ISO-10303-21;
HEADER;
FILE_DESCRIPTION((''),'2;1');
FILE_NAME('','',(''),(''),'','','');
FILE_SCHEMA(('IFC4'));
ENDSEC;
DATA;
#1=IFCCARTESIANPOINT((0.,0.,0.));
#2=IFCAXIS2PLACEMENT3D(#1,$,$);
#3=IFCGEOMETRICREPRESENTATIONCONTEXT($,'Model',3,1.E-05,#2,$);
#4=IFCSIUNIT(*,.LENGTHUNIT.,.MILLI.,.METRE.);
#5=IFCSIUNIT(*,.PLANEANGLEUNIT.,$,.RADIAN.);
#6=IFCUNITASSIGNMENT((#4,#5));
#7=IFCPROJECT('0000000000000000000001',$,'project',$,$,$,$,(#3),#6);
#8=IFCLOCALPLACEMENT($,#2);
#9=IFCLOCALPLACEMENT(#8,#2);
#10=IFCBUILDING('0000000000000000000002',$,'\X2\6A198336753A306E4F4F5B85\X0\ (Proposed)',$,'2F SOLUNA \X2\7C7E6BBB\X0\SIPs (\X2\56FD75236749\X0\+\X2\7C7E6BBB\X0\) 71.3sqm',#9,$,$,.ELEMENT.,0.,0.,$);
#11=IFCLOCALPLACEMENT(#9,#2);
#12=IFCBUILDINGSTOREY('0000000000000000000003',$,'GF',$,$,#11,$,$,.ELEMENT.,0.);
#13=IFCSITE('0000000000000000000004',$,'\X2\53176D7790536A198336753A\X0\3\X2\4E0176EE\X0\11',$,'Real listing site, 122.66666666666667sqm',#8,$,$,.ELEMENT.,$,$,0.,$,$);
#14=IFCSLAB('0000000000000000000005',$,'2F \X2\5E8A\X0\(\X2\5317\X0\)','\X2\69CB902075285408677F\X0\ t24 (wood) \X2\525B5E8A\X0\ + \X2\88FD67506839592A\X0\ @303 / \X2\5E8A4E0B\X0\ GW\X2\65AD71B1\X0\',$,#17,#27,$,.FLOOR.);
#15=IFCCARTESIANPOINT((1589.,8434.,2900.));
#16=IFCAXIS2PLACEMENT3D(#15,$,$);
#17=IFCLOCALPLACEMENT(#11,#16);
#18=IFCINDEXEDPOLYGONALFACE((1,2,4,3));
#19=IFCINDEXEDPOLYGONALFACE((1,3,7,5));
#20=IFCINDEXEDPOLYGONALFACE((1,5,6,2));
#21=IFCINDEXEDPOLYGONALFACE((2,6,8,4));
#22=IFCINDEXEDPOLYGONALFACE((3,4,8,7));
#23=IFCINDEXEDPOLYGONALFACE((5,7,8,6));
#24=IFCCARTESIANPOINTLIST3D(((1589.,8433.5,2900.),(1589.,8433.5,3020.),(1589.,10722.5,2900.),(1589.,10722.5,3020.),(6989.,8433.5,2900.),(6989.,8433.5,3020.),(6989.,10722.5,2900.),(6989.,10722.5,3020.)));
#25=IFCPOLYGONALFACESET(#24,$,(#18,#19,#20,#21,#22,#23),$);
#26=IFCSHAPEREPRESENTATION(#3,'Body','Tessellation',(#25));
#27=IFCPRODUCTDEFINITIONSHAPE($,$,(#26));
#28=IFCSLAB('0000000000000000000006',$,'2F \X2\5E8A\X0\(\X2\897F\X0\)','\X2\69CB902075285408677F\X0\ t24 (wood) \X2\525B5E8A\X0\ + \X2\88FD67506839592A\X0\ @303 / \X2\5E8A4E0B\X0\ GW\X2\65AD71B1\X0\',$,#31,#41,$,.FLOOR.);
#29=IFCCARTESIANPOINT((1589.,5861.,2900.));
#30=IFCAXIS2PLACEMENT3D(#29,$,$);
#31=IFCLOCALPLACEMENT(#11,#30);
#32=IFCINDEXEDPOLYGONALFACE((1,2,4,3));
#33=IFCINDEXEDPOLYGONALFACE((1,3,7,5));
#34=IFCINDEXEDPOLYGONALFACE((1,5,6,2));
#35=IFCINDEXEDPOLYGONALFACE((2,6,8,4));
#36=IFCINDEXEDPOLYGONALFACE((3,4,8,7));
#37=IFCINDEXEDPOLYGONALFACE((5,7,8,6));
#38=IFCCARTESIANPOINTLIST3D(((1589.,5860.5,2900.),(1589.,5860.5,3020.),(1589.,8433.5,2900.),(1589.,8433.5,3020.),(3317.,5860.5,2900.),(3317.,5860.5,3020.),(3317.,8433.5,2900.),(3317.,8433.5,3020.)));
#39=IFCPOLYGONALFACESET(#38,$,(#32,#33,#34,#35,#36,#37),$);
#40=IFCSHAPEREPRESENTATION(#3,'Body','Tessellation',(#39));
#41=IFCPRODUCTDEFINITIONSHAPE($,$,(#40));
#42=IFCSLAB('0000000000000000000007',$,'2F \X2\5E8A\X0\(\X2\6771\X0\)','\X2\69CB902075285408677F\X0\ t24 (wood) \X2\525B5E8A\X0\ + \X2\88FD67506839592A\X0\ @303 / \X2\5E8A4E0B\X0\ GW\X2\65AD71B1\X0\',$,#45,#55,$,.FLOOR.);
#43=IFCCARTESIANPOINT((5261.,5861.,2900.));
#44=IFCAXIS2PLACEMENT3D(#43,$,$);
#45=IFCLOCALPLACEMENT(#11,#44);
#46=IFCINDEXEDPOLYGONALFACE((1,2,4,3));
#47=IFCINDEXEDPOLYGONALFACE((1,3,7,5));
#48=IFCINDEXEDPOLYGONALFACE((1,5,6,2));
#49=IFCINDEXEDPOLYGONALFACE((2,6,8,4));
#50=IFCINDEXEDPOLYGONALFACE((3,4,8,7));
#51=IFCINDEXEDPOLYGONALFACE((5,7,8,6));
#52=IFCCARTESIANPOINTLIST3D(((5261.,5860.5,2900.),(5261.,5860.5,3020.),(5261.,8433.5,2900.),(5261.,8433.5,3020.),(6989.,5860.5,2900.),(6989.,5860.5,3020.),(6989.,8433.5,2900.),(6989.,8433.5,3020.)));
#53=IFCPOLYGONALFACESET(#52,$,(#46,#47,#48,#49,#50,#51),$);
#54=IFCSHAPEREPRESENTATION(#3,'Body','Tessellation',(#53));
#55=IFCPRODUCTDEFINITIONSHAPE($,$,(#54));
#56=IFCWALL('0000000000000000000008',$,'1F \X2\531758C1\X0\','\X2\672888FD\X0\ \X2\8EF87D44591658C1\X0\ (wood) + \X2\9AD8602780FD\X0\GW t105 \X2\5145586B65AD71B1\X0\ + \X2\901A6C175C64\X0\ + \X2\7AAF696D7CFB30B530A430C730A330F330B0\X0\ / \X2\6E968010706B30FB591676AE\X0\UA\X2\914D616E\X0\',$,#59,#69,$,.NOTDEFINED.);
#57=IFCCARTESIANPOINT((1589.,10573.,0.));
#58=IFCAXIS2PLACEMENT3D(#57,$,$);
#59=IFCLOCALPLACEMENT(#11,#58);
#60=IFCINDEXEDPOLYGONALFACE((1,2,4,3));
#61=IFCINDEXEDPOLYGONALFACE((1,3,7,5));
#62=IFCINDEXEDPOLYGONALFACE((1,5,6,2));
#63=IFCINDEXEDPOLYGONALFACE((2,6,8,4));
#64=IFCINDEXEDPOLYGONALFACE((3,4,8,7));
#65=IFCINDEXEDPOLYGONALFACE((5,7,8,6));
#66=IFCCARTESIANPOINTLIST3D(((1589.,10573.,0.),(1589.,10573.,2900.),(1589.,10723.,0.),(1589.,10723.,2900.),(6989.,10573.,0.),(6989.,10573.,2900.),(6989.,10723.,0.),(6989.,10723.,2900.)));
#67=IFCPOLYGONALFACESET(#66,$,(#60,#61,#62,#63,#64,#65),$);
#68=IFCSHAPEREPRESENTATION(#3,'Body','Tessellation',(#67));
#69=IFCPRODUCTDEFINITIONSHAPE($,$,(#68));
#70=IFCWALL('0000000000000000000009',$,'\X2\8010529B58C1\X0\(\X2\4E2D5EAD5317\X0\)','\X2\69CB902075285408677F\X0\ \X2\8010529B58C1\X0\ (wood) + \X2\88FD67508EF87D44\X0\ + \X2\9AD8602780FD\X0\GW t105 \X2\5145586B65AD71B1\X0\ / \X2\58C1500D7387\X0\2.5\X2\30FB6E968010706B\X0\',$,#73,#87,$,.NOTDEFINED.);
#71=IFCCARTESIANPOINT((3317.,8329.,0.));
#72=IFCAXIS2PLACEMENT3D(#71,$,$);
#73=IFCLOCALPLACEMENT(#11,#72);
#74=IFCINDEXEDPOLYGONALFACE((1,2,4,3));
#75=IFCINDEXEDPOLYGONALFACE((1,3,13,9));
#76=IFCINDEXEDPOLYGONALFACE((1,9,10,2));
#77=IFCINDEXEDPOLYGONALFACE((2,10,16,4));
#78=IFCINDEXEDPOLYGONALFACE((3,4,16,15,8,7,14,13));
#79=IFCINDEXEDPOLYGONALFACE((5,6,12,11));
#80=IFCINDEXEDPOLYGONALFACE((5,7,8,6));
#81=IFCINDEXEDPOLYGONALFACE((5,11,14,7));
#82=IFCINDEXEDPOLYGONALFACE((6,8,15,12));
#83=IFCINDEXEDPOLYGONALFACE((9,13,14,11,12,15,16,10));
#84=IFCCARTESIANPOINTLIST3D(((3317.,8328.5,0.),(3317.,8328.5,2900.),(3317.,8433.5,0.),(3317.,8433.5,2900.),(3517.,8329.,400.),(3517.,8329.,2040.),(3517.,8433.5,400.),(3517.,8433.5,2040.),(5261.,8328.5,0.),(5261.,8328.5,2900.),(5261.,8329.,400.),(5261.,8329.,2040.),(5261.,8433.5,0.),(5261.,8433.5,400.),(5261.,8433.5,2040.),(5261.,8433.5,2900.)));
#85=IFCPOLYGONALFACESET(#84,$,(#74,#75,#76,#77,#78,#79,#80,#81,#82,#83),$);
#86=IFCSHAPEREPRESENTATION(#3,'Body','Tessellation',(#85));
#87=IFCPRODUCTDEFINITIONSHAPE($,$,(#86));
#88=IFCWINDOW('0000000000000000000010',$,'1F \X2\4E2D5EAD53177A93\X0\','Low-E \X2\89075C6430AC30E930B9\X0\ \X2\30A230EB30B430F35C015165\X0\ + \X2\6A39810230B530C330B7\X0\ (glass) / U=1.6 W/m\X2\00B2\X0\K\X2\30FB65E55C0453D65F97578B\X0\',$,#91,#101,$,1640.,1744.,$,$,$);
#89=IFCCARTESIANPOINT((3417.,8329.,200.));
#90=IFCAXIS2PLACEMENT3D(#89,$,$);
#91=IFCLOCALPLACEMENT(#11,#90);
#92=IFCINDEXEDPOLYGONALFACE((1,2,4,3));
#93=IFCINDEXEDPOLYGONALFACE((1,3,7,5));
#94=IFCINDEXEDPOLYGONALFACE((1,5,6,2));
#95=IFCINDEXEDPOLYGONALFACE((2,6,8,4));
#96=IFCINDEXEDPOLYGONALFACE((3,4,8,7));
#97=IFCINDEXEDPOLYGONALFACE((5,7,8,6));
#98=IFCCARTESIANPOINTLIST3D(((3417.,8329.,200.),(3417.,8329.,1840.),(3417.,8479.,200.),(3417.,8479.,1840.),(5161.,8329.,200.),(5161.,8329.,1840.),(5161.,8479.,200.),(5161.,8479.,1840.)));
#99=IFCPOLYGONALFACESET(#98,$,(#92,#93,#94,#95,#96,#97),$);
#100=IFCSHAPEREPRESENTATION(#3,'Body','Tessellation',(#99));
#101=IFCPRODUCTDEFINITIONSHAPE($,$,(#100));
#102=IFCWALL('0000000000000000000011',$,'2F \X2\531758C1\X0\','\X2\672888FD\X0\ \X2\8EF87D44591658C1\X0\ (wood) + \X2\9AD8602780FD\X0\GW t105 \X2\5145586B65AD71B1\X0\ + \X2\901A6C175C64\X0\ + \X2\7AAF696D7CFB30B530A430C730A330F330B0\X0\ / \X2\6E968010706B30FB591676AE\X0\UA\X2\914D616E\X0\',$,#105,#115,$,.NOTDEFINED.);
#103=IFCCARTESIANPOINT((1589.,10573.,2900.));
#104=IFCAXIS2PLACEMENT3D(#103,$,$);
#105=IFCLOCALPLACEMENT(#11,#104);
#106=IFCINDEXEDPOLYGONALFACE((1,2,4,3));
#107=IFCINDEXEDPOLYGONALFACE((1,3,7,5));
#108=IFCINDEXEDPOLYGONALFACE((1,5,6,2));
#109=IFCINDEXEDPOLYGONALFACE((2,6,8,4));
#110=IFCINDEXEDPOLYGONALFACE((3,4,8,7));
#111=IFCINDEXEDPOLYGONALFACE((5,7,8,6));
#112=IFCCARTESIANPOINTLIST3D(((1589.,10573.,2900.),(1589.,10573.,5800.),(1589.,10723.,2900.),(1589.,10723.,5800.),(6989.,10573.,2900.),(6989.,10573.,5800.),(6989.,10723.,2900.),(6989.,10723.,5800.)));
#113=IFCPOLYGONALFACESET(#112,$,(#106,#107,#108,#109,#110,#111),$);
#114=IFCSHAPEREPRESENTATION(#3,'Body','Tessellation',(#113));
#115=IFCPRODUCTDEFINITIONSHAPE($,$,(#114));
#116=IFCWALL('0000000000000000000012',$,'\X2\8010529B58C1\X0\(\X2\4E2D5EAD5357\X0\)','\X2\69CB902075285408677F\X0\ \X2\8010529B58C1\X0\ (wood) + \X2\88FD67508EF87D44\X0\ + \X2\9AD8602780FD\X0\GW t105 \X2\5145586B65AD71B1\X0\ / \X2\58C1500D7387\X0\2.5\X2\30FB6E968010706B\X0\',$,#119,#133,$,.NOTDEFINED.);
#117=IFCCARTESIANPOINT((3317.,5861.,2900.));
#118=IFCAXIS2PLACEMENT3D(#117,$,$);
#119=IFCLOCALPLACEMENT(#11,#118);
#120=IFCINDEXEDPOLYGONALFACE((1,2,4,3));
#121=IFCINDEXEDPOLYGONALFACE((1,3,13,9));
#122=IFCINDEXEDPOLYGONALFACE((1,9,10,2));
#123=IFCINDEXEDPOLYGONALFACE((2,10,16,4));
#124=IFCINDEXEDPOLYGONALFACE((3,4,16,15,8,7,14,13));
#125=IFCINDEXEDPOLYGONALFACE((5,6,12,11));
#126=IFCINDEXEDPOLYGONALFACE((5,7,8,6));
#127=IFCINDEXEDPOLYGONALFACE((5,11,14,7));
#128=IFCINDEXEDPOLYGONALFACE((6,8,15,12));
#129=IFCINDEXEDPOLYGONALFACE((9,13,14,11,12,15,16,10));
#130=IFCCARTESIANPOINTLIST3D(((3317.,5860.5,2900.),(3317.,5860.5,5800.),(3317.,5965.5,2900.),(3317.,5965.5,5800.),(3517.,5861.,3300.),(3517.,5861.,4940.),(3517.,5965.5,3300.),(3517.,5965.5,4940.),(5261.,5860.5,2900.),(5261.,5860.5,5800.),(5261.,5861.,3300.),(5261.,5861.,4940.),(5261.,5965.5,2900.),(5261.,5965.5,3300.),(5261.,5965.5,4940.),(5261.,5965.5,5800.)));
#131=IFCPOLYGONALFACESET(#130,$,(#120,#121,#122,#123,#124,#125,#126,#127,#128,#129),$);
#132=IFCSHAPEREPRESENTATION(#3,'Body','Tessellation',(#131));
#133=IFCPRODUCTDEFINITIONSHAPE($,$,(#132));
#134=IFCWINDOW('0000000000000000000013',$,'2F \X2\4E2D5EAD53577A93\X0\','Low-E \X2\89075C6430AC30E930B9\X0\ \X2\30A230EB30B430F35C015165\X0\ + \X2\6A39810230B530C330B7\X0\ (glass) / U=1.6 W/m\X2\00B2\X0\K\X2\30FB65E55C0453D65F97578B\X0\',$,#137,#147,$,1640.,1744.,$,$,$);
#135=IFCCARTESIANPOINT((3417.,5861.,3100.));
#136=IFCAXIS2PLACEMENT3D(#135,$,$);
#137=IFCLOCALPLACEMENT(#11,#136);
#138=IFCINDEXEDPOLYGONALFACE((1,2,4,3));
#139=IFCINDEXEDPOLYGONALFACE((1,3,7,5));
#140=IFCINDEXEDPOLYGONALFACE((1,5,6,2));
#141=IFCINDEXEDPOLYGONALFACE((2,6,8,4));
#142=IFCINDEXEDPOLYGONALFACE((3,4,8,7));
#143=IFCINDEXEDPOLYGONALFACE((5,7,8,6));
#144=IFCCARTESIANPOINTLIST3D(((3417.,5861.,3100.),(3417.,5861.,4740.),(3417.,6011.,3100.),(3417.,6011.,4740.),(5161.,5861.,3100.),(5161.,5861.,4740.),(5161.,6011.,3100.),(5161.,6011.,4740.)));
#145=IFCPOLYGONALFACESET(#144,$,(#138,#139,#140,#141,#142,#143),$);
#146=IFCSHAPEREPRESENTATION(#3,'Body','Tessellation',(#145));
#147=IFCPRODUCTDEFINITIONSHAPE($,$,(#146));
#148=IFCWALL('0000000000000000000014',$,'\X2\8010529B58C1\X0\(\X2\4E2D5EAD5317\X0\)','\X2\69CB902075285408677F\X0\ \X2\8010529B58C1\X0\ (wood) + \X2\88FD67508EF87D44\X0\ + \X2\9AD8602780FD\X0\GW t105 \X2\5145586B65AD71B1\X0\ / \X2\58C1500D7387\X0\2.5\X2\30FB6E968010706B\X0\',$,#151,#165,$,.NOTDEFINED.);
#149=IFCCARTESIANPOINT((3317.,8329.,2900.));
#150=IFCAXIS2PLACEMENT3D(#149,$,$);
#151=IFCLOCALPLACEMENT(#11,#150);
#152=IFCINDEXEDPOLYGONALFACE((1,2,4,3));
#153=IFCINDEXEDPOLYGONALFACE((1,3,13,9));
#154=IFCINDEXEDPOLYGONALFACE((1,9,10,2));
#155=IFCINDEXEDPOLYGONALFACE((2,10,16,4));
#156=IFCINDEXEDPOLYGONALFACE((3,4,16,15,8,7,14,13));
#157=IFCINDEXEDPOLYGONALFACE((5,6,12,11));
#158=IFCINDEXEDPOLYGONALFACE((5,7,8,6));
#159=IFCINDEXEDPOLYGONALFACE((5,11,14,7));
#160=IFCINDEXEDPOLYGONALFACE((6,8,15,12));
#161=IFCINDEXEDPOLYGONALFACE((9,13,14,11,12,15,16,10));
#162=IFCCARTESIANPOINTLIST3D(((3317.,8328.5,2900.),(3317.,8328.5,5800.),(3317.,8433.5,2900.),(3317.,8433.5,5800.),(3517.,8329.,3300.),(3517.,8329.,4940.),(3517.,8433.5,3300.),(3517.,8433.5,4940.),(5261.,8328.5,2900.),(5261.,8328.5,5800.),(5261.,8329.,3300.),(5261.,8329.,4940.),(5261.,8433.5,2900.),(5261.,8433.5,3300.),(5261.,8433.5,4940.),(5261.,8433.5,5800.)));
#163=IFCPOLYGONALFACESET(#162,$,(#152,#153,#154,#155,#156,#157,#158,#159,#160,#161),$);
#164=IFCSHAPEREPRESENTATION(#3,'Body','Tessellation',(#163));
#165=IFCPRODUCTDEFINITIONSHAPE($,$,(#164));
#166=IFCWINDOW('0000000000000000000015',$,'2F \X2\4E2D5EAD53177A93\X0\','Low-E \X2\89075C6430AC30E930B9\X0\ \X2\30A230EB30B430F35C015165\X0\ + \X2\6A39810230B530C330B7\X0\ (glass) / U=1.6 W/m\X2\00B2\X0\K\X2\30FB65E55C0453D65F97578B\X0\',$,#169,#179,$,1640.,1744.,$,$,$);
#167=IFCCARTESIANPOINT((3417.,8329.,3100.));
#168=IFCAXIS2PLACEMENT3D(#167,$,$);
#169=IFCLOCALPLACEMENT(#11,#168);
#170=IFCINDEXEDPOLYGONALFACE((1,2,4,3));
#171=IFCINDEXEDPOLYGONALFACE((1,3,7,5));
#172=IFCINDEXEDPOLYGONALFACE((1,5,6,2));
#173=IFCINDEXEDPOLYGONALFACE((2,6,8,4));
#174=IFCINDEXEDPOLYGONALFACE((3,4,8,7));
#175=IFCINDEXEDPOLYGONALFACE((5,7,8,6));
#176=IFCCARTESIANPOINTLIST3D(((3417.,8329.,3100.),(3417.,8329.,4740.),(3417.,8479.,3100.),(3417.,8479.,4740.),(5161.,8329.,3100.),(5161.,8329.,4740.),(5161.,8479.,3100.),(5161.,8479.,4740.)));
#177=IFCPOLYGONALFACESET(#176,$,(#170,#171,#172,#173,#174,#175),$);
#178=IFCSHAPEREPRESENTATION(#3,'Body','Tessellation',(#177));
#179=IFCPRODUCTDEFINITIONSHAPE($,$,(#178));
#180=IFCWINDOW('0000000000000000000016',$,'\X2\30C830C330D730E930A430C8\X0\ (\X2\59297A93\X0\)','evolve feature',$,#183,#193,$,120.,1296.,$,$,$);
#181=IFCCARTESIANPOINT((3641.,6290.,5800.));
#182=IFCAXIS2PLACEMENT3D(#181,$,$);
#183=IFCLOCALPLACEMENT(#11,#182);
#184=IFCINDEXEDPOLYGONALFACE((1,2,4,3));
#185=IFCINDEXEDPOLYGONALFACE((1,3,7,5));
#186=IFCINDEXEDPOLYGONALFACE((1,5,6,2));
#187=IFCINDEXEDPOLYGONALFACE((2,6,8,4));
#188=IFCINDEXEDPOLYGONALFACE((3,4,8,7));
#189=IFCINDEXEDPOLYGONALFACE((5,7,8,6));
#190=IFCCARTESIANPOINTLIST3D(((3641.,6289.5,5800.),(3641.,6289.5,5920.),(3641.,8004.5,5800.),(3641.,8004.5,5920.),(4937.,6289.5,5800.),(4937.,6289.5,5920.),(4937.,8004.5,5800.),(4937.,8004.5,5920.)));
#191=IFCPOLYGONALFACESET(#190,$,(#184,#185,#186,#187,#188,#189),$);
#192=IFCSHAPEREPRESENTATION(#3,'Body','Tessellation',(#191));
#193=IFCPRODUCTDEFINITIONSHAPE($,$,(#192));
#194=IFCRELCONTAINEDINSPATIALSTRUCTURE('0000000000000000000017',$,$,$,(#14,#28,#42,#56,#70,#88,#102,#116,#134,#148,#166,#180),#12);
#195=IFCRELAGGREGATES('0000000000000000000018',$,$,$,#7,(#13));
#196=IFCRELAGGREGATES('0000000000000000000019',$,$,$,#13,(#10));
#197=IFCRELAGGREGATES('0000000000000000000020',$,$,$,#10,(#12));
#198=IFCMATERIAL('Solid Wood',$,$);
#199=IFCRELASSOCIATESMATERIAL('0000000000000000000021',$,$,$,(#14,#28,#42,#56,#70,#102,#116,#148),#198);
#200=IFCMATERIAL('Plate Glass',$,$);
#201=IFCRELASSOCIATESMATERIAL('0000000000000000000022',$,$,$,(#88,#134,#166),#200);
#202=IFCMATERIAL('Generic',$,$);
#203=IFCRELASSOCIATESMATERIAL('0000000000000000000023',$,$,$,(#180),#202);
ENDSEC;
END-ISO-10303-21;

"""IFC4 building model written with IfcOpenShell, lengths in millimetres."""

from ifc_helpers import new_model, si_unit, frame, frame_2d, origin, place, context, project, spatial, rectangle, extrude, material, element, fill, save


model = new_model("IFC4")

# Units and contexts
model_context = context("Model", 3, precision=1e-05, world=origin())
ifc_project = project(units=[si_unit("LENGTHUNIT", "METRE", prefix="MILLI"), si_unit("PLANEANGLEUNIT", "RADIAN")], contexts=[model_context])

# Site, building, storey
site_placement = place(None, origin())
site = spatial("IfcSite", under=ifc_project, at=site_placement, Name="北海道標茶町3丁目11", ObjectType="Real listing site, 122.66666666666667sqm", CompositionType="ELEMENT", RefElevation=0.0)
building_placement = place(site_placement, origin())
building = spatial("IfcBuilding", under=site, at=building_placement, Name="標茶町の住宅 (Proposed)", ObjectType="2F SOLUNA 籾殻SIPs (国産杉+籾殻) 71.3sqm", CompositionType="ELEMENT", ElevationOfRefHeight=0.0, ElevationOfTerrain=0.0)
storey_placement = place(building_placement, origin())
storey = spatial("IfcBuildingStorey", under=building, at=storey_placement, Name="GF", CompositionType="ELEMENT", Elevation=0.0)

# Slabs
ifc_material_1 = material(Name="Solid Wood")
slab_1_placement = place(storey_placement, frame((1589.0, 8434.0, 2900.0)))
element("IfcSlab", 1, at=slab_1_placement, inside=storey, material=ifc_material_1, Name="2F 床(北)", Description="構造用合板 t24 (wood) 剛床 + 製材根太 @303 / 床下 GW断熱", PredefinedType="FLOOR", context=model_context, shape_type="SweptSolid", body=[
    extrude(rectangle(XDim=5400.0, YDim=2289.0, at=frame_2d((2700.0, 1144.0))), frame((1589.0, 8434.0, 2900.0)), (0.0, 0.0, 1.0), 120.0),
])
slab_2_placement = place(storey_placement, frame((1589.0, 5861.0, 2900.0)))
element("IfcSlab", 2, at=slab_2_placement, inside=storey, material=ifc_material_1, Name="2F 床(西)", Description="構造用合板 t24 (wood) 剛床 + 製材根太 @303 / 床下 GW断熱", PredefinedType="FLOOR", context=model_context, shape_type="SweptSolid", body=[
    extrude(rectangle(XDim=1728.0, YDim=2573.0, at=frame_2d((864.0, 1286.0))), frame((1589.0, 5861.0, 2900.0)), (0.0, 0.0, 1.0), 120.0),
])
slab_3_placement = place(storey_placement, frame((5261.0, 5861.0, 2900.0)))
element("IfcSlab", 3, at=slab_3_placement, inside=storey, material=ifc_material_1, Name="2F 床(東)", Description="構造用合板 t24 (wood) 剛床 + 製材根太 @303 / 床下 GW断熱", PredefinedType="FLOOR", context=model_context, shape_type="SweptSolid", body=[
    extrude(rectangle(XDim=1728.0, YDim=2573.0, at=frame_2d((864.0, 1286.0))), frame((5261.0, 5861.0, 2900.0)), (0.0, 0.0, 1.0), 120.0),
])

# Wall
wall_1_placement = place(storey_placement, frame((1589.0, 10573.0, 0.0)))
element("IfcWall", 4, at=wall_1_placement, inside=storey, material=ifc_material_1, Name="1F 北壁", Description="木製 軸組外壁 (wood) + 高性能GW t105 充填断熱 + 通気層 + 窯業系サイディング / 準耐火・外皮UA配慮", PredefinedType="NOTDEFINED", context=model_context, shape_type="SweptSolid", body=[
    extrude(rectangle(XDim=5400.0, YDim=150.0, at=frame_2d((2700.0, 75.0))), frame((1589.0, 10573.0, 0.0)), (0.0, 0.0, 1.0), 2900.0),
])

# Wall, opening, window
wall_2_placement = place(storey_placement, frame((3317.0, 8329.0, 0.0)))
wall_2 = element("IfcWall", 5, at=wall_2_placement, inside=storey, material=ifc_material_1, Name="耐力壁(中庭北)", Description="構造用合板 耐力壁 (wood) + 製材軸組 + 高性能GW t105 充填断熱 / 壁倍率2.5・準耐火", PredefinedType="NOTDEFINED", context=model_context, shape_type="SweptSolid", body=[
    extrude(rectangle(XDim=1944.0, YDim=105.0, at=frame_2d((972.0, 52.0))), frame((3317.0, 8329.0, 0.0)), (0.0, 0.0, 1.0), 2900.0),
])
opening_1_placement = place(storey_placement, frame((3417.0, 8329.0, 200.0)))
opening_1 = element("IfcOpeningElement", 6, at=opening_1_placement, cuts=wall_2, PredefinedType="NOTDEFINED", context=model_context, shape_type="SweptSolid", body=[
    extrude(rectangle(XDim=1744.0, YDim=150.0, at=frame_2d((872.0, 75.0))), frame((3417.0, 8329.0, 200.0)), (0.0, 0.0, 1.0), 1640.0),
])
ifc_material_2 = material(Name="Plate Glass")
window_1_placement = place(storey_placement, frame((3417.0, 8329.0, 200.0)))
window_1 = element("IfcWindow", 7, at=window_1_placement, inside=storey, material=ifc_material_2, Name="1F 中庭北窓", Description="Low-E 複層ガラス アルゴン封入 + 樹脂サッシ (glass) / U=1.6 W/m²K・日射取得型", OverallHeight=1640.0, OverallWidth=1744.0, context=model_context, shape_type="SweptSolid", body=[
    extrude(rectangle(XDim=1744.0, YDim=150.0, at=frame_2d((872.0, 75.0))), frame((3417.0, 8329.0, 200.0)), (0.0, 0.0, 1.0), 1640.0),
])
fill(opening_1, window_1)

# Wall
wall_3_placement = place(storey_placement, frame((1589.0, 10573.0, 2900.0)))
element("IfcWall", 8, at=wall_3_placement, inside=storey, material=ifc_material_1, Name="2F 北壁", Description="木製 軸組外壁 (wood) + 高性能GW t105 充填断熱 + 通気層 + 窯業系サイディング / 準耐火・外皮UA配慮", PredefinedType="NOTDEFINED", context=model_context, shape_type="SweptSolid", body=[
    extrude(rectangle(XDim=5400.0, YDim=150.0, at=frame_2d((2700.0, 75.0))), frame((1589.0, 10573.0, 2900.0)), (0.0, 0.0, 1.0), 2900.0),
])

# Walls, openings, windows
wall_4_placement = place(storey_placement, frame((3317.0, 5861.0, 2900.0)))
wall_4 = element("IfcWall", 9, at=wall_4_placement, inside=storey, material=ifc_material_1, Name="耐力壁(中庭南)", Description="構造用合板 耐力壁 (wood) + 製材軸組 + 高性能GW t105 充填断熱 / 壁倍率2.5・準耐火", PredefinedType="NOTDEFINED", context=model_context, shape_type="SweptSolid", body=[
    extrude(rectangle(XDim=1944.0, YDim=105.0, at=frame_2d((972.0, 52.0))), frame((3317.0, 5861.0, 2900.0)), (0.0, 0.0, 1.0), 2900.0),
])
opening_2_placement = place(storey_placement, frame((3417.0, 5861.0, 3100.0)))
opening_2 = element("IfcOpeningElement", 10, at=opening_2_placement, cuts=wall_4, PredefinedType="NOTDEFINED", context=model_context, shape_type="SweptSolid", body=[
    extrude(rectangle(XDim=1744.0, YDim=150.0, at=frame_2d((872.0, 75.0))), frame((3417.0, 5861.0, 3100.0)), (0.0, 0.0, 1.0), 1640.0),
])
window_2_placement = place(storey_placement, frame((3417.0, 5861.0, 3100.0)))
window_2 = element("IfcWindow", 11, at=window_2_placement, inside=storey, material=ifc_material_2, Name="2F 中庭南窓", Description="Low-E 複層ガラス アルゴン封入 + 樹脂サッシ (glass) / U=1.6 W/m²K・日射取得型", OverallHeight=1640.0, OverallWidth=1744.0, context=model_context, shape_type="SweptSolid", body=[
    extrude(rectangle(XDim=1744.0, YDim=150.0, at=frame_2d((872.0, 75.0))), frame((3417.0, 5861.0, 3100.0)), (0.0, 0.0, 1.0), 1640.0),
])
fill(opening_2, window_2)
wall_5_placement = place(storey_placement, frame((3317.0, 8329.0, 2900.0)))
wall_5 = element("IfcWall", 12, at=wall_5_placement, inside=storey, material=ifc_material_1, Name="耐力壁(中庭北)", Description="構造用合板 耐力壁 (wood) + 製材軸組 + 高性能GW t105 充填断熱 / 壁倍率2.5・準耐火", PredefinedType="NOTDEFINED", context=model_context, shape_type="SweptSolid", body=[
    extrude(rectangle(XDim=1944.0, YDim=105.0, at=frame_2d((972.0, 52.0))), frame((3317.0, 8329.0, 2900.0)), (0.0, 0.0, 1.0), 2900.0),
])
opening_3_placement = place(storey_placement, frame((3417.0, 8329.0, 3100.0)))
opening_3 = element("IfcOpeningElement", 13, at=opening_3_placement, cuts=wall_5, PredefinedType="NOTDEFINED", context=model_context, shape_type="SweptSolid", body=[
    extrude(rectangle(XDim=1744.0, YDim=150.0, at=frame_2d((872.0, 75.0))), frame((3417.0, 8329.0, 3100.0)), (0.0, 0.0, 1.0), 1640.0),
])
window_3_placement = place(storey_placement, frame((3417.0, 8329.0, 3100.0)))
window_3 = element("IfcWindow", 14, at=window_3_placement, inside=storey, material=ifc_material_2, Name="2F 中庭北窓", Description="Low-E 複層ガラス アルゴン封入 + 樹脂サッシ (glass) / U=1.6 W/m²K・日射取得型", OverallHeight=1640.0, OverallWidth=1744.0, context=model_context, shape_type="SweptSolid", body=[
    extrude(rectangle(XDim=1744.0, YDim=150.0, at=frame_2d((872.0, 75.0))), frame((3417.0, 8329.0, 3100.0)), (0.0, 0.0, 1.0), 1640.0),
])
fill(opening_3, window_3)

# Window
ifc_material_3 = material(Name="Generic")
window_4_placement = place(storey_placement, frame((3641.0, 6290.0, 5800.0)))
element("IfcWindow", 15, at=window_4_placement, inside=storey, material=ifc_material_3, Name="トップライト (天窓)", Description="evolve feature", OverallHeight=120.0, OverallWidth=1296.0, context=model_context, shape_type="SweptSolid", body=[
    extrude(rectangle(XDim=1296.0, YDim=1715.0, at=frame_2d((648.0, 857.0))), frame((3641.0, 6290.0, 5800.0)), (0.0, 0.0, 1.0), 120.0),
])

save(model, "model.ifc")
